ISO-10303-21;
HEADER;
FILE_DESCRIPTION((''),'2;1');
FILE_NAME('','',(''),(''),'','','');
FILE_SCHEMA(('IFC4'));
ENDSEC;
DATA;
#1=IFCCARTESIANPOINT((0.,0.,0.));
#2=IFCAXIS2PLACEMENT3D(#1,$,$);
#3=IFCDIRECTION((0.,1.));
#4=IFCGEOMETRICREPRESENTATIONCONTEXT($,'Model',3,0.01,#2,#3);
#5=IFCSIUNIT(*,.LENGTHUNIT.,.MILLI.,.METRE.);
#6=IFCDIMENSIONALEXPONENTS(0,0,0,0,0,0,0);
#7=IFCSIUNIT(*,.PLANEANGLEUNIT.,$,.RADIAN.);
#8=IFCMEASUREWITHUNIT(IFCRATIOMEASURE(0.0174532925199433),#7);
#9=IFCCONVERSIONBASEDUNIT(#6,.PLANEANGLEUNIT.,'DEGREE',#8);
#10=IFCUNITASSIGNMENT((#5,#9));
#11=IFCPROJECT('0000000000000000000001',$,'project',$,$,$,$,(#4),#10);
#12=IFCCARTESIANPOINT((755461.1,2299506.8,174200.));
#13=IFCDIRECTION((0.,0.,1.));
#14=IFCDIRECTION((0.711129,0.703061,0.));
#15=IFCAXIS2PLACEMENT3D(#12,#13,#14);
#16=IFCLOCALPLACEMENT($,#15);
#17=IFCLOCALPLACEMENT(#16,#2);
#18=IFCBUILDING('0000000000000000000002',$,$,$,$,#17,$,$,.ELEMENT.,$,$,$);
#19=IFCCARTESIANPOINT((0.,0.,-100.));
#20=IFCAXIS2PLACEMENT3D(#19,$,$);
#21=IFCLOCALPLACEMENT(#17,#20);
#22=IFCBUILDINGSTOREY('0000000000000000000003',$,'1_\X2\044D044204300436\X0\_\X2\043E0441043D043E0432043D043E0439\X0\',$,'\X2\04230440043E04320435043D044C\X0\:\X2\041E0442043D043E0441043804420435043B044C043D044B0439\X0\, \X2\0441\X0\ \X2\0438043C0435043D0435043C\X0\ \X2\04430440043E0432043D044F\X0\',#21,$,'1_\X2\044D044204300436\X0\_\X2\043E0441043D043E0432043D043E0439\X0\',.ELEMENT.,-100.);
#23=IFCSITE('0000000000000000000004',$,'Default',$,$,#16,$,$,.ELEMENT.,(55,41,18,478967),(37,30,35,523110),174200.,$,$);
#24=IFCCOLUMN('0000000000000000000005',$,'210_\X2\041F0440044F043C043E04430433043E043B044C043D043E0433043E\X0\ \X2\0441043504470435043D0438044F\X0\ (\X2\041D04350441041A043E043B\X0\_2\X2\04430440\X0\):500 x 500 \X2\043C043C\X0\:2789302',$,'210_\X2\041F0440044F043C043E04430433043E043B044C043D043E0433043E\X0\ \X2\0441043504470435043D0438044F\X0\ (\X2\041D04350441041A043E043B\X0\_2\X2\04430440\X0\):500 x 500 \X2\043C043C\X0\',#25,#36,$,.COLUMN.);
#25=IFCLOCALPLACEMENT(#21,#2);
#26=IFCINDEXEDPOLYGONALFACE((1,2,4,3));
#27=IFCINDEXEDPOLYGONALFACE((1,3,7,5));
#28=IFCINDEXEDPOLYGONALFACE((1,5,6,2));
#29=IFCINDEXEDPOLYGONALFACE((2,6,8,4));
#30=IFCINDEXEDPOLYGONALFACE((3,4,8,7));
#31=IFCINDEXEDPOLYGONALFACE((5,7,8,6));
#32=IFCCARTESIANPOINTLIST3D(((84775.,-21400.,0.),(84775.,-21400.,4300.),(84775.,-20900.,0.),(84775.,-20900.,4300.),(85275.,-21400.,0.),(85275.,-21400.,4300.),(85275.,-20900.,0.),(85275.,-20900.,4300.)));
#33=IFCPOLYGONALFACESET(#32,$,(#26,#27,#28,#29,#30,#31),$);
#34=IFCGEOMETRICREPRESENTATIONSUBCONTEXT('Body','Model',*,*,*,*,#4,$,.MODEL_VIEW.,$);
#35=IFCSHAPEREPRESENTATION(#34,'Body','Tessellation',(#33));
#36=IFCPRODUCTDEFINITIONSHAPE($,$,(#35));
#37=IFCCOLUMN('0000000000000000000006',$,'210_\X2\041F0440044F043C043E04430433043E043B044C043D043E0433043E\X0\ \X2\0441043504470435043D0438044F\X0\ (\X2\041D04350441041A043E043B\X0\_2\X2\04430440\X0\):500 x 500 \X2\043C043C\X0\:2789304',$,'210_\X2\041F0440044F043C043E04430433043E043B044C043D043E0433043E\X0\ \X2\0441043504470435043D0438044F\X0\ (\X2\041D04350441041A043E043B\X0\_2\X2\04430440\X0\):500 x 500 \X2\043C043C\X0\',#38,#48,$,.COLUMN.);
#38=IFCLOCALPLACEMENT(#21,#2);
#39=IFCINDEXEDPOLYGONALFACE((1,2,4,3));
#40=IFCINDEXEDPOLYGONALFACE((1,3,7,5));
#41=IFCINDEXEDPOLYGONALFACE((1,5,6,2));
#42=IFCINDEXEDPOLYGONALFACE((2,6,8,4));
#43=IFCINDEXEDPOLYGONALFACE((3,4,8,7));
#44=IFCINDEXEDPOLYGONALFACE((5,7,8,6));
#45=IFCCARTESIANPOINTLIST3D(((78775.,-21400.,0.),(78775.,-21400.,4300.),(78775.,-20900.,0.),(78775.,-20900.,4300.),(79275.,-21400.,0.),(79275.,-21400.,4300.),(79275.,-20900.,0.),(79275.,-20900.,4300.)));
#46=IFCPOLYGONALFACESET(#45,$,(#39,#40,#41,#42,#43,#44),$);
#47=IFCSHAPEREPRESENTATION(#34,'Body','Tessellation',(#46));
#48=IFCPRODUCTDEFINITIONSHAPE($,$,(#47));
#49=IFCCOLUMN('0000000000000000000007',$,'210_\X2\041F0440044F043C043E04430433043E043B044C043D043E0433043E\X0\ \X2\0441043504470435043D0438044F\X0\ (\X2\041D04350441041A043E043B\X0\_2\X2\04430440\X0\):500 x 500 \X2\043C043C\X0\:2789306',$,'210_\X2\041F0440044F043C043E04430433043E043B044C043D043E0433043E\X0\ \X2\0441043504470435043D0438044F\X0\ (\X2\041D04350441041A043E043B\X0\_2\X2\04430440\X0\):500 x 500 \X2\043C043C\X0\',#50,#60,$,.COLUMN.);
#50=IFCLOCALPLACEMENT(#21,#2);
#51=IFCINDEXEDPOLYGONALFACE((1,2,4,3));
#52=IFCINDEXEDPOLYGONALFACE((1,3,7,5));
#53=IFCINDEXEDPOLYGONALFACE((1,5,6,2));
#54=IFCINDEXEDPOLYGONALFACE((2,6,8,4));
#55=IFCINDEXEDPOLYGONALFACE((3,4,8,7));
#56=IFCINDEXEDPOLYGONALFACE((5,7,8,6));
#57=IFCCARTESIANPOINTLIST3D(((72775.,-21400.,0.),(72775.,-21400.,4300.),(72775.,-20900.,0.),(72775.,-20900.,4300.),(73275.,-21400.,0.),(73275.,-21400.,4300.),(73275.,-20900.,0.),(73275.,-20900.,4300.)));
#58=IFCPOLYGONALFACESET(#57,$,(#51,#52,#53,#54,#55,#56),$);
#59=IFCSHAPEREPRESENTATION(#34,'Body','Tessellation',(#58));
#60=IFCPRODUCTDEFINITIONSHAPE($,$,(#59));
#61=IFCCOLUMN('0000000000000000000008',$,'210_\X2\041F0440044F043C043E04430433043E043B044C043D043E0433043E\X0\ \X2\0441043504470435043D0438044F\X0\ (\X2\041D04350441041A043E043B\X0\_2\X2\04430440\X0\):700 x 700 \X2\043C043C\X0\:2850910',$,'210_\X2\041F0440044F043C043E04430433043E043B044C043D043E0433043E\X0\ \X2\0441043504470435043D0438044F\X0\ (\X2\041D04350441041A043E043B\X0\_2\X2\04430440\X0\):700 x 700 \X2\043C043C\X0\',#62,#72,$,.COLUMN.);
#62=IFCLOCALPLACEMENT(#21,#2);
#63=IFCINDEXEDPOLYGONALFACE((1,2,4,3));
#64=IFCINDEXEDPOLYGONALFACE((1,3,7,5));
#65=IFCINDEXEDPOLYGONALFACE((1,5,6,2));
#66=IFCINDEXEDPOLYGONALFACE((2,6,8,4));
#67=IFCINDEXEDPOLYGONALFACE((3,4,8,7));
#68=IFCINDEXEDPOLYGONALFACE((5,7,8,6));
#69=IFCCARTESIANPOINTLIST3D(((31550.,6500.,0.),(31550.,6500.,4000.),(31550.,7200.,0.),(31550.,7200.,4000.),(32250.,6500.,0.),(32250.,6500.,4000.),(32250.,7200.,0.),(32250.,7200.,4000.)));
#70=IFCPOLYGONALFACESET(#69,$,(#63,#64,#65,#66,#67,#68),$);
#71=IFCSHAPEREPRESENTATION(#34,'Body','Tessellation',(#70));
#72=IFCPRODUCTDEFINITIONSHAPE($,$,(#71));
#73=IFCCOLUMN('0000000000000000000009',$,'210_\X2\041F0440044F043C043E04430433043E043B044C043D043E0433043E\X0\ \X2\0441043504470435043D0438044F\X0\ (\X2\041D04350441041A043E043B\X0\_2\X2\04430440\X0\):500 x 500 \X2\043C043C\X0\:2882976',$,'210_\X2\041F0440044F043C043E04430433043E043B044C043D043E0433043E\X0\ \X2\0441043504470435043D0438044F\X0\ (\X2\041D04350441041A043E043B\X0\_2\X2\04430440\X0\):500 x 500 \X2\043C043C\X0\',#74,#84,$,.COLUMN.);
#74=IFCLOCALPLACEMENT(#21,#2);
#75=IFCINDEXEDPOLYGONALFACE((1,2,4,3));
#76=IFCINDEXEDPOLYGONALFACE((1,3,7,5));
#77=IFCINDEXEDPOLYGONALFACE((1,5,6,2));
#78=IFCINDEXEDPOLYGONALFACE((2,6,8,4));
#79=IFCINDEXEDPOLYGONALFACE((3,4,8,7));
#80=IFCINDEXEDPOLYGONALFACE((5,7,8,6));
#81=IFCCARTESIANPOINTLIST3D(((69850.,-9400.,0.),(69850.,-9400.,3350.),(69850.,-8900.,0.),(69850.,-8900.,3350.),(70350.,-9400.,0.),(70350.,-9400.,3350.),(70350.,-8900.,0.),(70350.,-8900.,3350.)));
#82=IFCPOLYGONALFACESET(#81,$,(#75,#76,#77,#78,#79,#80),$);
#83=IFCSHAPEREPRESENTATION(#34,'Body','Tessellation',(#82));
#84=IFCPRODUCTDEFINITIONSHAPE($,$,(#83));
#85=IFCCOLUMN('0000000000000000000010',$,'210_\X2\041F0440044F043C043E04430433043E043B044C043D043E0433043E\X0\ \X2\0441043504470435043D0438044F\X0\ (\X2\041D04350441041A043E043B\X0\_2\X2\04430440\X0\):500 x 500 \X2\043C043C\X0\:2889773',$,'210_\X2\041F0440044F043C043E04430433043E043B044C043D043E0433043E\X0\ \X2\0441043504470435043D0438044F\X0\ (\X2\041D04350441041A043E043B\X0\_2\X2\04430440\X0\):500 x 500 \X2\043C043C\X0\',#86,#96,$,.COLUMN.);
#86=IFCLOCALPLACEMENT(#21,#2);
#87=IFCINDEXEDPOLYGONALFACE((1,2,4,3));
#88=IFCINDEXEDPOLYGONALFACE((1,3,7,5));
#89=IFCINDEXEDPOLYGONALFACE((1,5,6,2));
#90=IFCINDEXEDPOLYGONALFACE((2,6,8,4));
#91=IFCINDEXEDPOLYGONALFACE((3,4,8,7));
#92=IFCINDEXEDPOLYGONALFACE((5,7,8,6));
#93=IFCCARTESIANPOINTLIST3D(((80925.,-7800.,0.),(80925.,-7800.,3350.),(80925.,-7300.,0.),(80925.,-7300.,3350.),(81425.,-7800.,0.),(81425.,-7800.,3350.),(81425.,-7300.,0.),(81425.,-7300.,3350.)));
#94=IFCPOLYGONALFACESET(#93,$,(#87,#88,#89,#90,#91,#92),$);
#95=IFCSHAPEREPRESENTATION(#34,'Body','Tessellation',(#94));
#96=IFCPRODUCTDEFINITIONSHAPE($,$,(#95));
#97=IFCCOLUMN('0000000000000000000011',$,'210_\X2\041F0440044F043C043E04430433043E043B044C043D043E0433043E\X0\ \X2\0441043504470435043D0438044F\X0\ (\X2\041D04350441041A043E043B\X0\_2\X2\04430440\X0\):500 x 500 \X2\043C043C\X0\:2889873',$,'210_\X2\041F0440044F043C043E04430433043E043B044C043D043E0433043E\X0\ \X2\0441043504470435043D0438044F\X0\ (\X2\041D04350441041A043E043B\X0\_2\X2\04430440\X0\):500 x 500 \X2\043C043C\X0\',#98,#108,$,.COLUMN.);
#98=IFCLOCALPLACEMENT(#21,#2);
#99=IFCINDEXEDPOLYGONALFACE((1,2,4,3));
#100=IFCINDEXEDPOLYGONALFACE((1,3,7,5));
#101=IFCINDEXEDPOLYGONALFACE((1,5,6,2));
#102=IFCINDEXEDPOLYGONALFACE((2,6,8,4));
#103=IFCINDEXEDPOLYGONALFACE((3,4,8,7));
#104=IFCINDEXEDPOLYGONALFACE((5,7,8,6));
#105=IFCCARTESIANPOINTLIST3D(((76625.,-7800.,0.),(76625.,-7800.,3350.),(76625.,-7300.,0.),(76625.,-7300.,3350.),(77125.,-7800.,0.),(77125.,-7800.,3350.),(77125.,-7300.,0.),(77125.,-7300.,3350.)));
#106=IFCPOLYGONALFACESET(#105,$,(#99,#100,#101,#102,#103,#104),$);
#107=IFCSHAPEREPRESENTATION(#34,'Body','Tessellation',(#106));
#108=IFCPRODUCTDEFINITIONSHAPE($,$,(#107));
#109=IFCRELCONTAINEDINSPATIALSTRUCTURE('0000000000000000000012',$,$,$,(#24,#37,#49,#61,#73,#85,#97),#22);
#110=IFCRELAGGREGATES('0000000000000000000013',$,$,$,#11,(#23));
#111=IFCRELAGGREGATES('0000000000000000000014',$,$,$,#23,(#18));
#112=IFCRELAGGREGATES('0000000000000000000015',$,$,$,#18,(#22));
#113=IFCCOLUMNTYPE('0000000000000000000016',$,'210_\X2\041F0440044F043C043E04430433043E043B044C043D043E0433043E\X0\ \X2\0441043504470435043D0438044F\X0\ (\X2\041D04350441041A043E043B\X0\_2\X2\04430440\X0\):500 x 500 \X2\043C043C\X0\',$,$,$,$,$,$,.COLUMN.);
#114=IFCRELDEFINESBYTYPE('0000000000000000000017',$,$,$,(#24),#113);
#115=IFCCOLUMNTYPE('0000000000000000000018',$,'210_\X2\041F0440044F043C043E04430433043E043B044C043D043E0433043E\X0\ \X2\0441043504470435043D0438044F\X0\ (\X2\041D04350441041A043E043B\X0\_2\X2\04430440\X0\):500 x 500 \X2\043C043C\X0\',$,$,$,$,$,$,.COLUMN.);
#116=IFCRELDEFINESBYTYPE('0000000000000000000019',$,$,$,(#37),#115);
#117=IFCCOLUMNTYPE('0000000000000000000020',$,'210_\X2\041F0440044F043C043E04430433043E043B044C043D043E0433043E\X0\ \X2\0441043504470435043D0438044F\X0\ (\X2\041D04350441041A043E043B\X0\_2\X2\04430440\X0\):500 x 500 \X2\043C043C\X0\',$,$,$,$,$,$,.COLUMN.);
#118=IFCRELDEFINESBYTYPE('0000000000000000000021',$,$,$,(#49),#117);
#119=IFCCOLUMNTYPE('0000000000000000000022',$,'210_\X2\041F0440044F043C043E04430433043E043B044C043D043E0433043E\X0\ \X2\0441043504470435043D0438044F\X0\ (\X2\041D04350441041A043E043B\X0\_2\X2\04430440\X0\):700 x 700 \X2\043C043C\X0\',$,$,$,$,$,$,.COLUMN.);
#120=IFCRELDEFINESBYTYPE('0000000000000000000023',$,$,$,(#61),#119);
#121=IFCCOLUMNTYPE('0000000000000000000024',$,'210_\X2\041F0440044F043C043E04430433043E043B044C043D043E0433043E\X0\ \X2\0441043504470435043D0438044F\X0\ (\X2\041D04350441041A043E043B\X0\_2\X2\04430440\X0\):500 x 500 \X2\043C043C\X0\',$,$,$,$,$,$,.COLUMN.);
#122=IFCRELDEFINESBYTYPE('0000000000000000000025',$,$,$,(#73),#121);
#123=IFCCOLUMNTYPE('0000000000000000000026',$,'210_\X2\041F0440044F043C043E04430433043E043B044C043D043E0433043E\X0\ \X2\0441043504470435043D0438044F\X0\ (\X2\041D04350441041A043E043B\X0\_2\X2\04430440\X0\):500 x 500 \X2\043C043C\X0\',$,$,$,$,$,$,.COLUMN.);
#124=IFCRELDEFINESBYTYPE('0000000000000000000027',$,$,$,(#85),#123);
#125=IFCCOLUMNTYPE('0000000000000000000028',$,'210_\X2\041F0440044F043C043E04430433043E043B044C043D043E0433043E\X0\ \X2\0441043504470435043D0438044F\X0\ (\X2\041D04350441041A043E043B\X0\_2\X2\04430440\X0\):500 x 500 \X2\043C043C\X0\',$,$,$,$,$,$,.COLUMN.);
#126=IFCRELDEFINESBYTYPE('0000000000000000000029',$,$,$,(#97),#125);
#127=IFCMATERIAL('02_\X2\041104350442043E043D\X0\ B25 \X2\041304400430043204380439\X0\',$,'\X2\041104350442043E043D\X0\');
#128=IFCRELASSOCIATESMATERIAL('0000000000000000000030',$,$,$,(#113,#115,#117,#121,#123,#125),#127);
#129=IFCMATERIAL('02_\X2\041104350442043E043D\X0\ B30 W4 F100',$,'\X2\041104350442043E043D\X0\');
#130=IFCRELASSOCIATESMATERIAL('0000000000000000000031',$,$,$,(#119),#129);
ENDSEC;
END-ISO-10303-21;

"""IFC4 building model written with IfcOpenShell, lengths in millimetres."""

from ifc_helpers import new_model, entity, si_unit, converted_unit, direction, frame, origin, place, context, subcontext, project, spatial, indexed_curve, outline, extrude, source, transform, mapped, material, type_object, type_shapes, element, save


model = new_model("IFC4")

# Units and contexts
model_context = context("Model", 3, precision=0.01, world=origin(), true_north=direction((0.0, 1.0)))
body_context = subcontext(model_context, "Body", "Model", "MODEL_VIEW")
ifc_project = project(units=[si_unit("LENGTHUNIT", "METRE", prefix="MILLI"), converted_unit("PLANEANGLEUNIT", "DEGREE", entity("IfcRatioMeasure", 0.0174532925199433), si_unit("PLANEANGLEUNIT", "RADIAN"), dimensions=[0, 0, 0, 0, 0, 0, 0])], contexts=[model_context])

# Site, building, storey
site_placement = place(None, frame((755461.1, 2299506.8, 174200.0), z_axis=(0.0, 0.0, 1.0), x_axis=(0.711129, 0.703061, 0.0)))
site = spatial("IfcSite", under=ifc_project, at=site_placement, Name="Default", CompositionType="ELEMENT", RefLatitude=(55, 41, 18, 478967), RefLongitude=(37, 30, 35, 523110), RefElevation=174200.0)
building_placement = place(site_placement, origin())
building = spatial("IfcBuilding", under=site, at=building_placement, CompositionType="ELEMENT")
storey_placement = place(building_placement, frame((0.0, 0.0, -100.0)))
storey = spatial("IfcBuildingStorey", under=building, at=storey_placement, Name="1_этаж_основной", ObjectType="Уровень:Относительный, с именем уровня", LongName="1_этаж_основной", CompositionType="ELEMENT", Elevation=-100.0)

# Columns
ifc_material_1 = material(Name="02_Бетон B25 Гравий", Category="Бетон")
ifc_material_2 = material(Name="02_Бетон B30 W4 F100", Category="Бетон")
column_type_1 = type_object("IfcColumnType", Name="210_Прямоугольного сечения (НесКол_2ур):500 x 500 мм", PredefinedType="COLUMN", material=ifc_material_1)
shared_shape_1 = source(origin(), body_context, "Body", "SweptSolid", [
    extrude(outline(indexed_curve([(-250.0, -250.0), (250.0, -250.0), (250.0, 250.0), (-250.0, 250.0), (-250.0, -250.0)], self_intersect=False)), frame((85025.0, -21150.0, -100.0), z_axis=(0.0, 0.0, 1.0), x_axis=(0.0, -1.0, 0.0)), (0.0, 0.0, 1.0), 4300.0),
])
type_shapes(column_type_1, [shared_shape_1])
column_1_placement = place(storey_placement, frame((0.0, 0.0, 100.0)))
element("IfcColumn", 1, at=column_1_placement, inside=storey, type_object=column_type_1, Name="210_Прямоугольного сечения (НесКол_2ур):500 x 500 мм:2789302", ObjectType="210_Прямоугольного сечения (НесКол_2ур):500 x 500 мм", PredefinedType="COLUMN", context=body_context, shape_type="MappedRepresentation", body=[
    mapped(shared_shape_1, transform((0.0, 0.0, 0.0), scale=1.0)),
])
column_type_2 = type_object("IfcColumnType", Name="210_Прямоугольного сечения (НесКол_2ур):500 x 500 мм", PredefinedType="COLUMN", material=ifc_material_1)
shared_shape_2 = source(origin(), body_context, "Body", "SweptSolid", [
    extrude(outline(indexed_curve([(-250.0, -250.0), (250.0, -250.0), (250.0, 250.0), (-250.0, 250.0), (-250.0, -250.0)], self_intersect=False)), frame((79025.0, -21150.0, -100.0), z_axis=(0.0, 0.0, 1.0), x_axis=(0.0, -1.0, 0.0)), (0.0, 0.0, 1.0), 4300.0),
])
type_shapes(column_type_2, [shared_shape_2])
column_2_placement = place(storey_placement, frame((0.0, 0.0, 100.0)))
element("IfcColumn", 2, at=column_2_placement, inside=storey, type_object=column_type_2, Name="210_Прямоугольного сечения (НесКол_2ур):500 x 500 мм:2789304", ObjectType="210_Прямоугольного сечения (НесКол_2ур):500 x 500 мм", PredefinedType="COLUMN", context=body_context, shape_type="MappedRepresentation", body=[
    mapped(shared_shape_2, transform((0.0, 0.0, 0.0), scale=1.0)),
])
column_type_3 = type_object("IfcColumnType", Name="210_Прямоугольного сечения (НесКол_2ур):500 x 500 мм", PredefinedType="COLUMN", material=ifc_material_1)
shared_shape_3 = source(origin(), body_context, "Body", "SweptSolid", [
    extrude(outline(indexed_curve([(-250.0, -250.0), (250.0, -250.0), (250.0, 250.0), (-250.0, 250.0), (-250.0, -250.0)], self_intersect=False)), frame((73025.0, -21150.0, -100.0), z_axis=(0.0, 0.0, 1.0), x_axis=(0.0, -1.0, 0.0)), (0.0, 0.0, 1.0), 4300.0),
])
type_shapes(column_type_3, [shared_shape_3])
column_3_placement = place(storey_placement, frame((0.0, 0.0, 100.0)))
element("IfcColumn", 3, at=column_3_placement, inside=storey, type_object=column_type_3, Name="210_Прямоугольного сечения (НесКол_2ур):500 x 500 мм:2789306", ObjectType="210_Прямоугольного сечения (НесКол_2ур):500 x 500 мм", PredefinedType="COLUMN", context=body_context, shape_type="MappedRepresentation", body=[
    mapped(shared_shape_3, transform((0.0, 0.0, 0.0), scale=1.0)),
])
column_type_4 = type_object("IfcColumnType", Name="210_Прямоугольного сечения (НесКол_2ур):700 x 700 мм", PredefinedType="COLUMN", material=ifc_material_2)
shared_shape_4 = source(origin(), body_context, "Body", "SweptSolid", [
    extrude(outline(indexed_curve([(-350.0, -350.0), (350.0, -350.0), (350.0, 350.0), (-350.0, 350.0), (-350.0, -350.0)], self_intersect=False)), frame((31900.0, 6850.0, -100.0), z_axis=(0.0, 0.0, 1.0), x_axis=(0.0, -1.0, 0.0)), (0.0, 0.0, 1.0), 4000.0),
])
type_shapes(column_type_4, [shared_shape_4])
column_4_placement = place(storey_placement, frame((0.0, 0.0, 100.0)))
element("IfcColumn", 4, at=column_4_placement, inside=storey, type_object=column_type_4, Name="210_Прямоугольного сечения (НесКол_2ур):700 x 700 мм:2850910", ObjectType="210_Прямоугольного сечения (НесКол_2ур):700 x 700 мм", PredefinedType="COLUMN", context=body_context, shape_type="MappedRepresentation", body=[
    mapped(shared_shape_4, transform((0.0, 0.0, 0.0), scale=1.0)),
])
column_type_5 = type_object("IfcColumnType", Name="210_Прямоугольного сечения (НесКол_2ур):500 x 500 мм", PredefinedType="COLUMN", material=ifc_material_1)
shared_shape_5 = source(origin(), body_context, "Body", "SweptSolid", [
    extrude(outline(indexed_curve([(-250.0, -250.0), (250.0, -250.0), (250.0, 250.0), (-250.0, 250.0), (-250.0, -250.0)], self_intersect=False)), frame((70100.0, -9150.0, -100.0), z_axis=(0.0, 0.0, 1.0), x_axis=(0.0, -1.0, 0.0)), (0.0, 0.0, 1.0), 3350.0),
])
type_shapes(column_type_5, [shared_shape_5])
column_5_placement = place(storey_placement, frame((0.0, 0.0, 100.0)))
element("IfcColumn", 5, at=column_5_placement, inside=storey, type_object=column_type_5, Name="210_Прямоугольного сечения (НесКол_2ур):500 x 500 мм:2882976", ObjectType="210_Прямоугольного сечения (НесКол_2ур):500 x 500 мм", PredefinedType="COLUMN", context=body_context, shape_type="MappedRepresentation", body=[
    mapped(shared_shape_5, transform((0.0, 0.0, 0.0), scale=1.0)),
])
column_type_6 = type_object("IfcColumnType", Name="210_Прямоугольного сечения (НесКол_2ур):500 x 500 мм", PredefinedType="COLUMN", material=ifc_material_1)
shared_shape_6 = source(origin(), body_context, "Body", "SweptSolid", [
    extrude(outline(indexed_curve([(-250.0, -250.0), (250.0, -250.0), (250.0, 250.0), (-250.0, 250.0), (-250.0, -250.0)], self_intersect=False)), frame((81175.0, -7550.0, -100.0), z_axis=(0.0, 0.0, 1.0), x_axis=(0.0, -1.0, 0.0)), (0.0, 0.0, 1.0), 3350.0),
])
type_shapes(column_type_6, [shared_shape_6])
column_6_placement = place(storey_placement, frame((0.0, 0.0, 100.0)))
element("IfcColumn", 6, at=column_6_placement, inside=storey, type_object=column_type_6, Name="210_Прямоугольного сечения (НесКол_2ур):500 x 500 мм:2889773", ObjectType="210_Прямоугольного сечения (НесКол_2ур):500 x 500 мм", PredefinedType="COLUMN", context=body_context, shape_type="MappedRepresentation", body=[
    mapped(shared_shape_6, transform((0.0, 0.0, 0.0), scale=1.0)),
])
column_type_7 = type_object("IfcColumnType", Name="210_Прямоугольного сечения (НесКол_2ур):500 x 500 мм", PredefinedType="COLUMN", material=ifc_material_1)
shared_shape_7 = source(origin(), body_context, "Body", "SweptSolid", [
    extrude(outline(indexed_curve([(-250.0, -250.0), (250.0, -250.0), (250.0, 250.0), (-250.0, 250.0), (-250.0, -250.0)], self_intersect=False)), frame((76875.0, -7550.0, -100.0), z_axis=(0.0, 0.0, 1.0), x_axis=(0.0, -1.0, 0.0)), (0.0, 0.0, 1.0), 3350.0),
])
type_shapes(column_type_7, [shared_shape_7])
column_7_placement = place(storey_placement, frame((0.0, 0.0, 100.0)))
element("IfcColumn", 7, at=column_7_placement, inside=storey, type_object=column_type_7, Name="210_Прямоугольного сечения (НесКол_2ур):500 x 500 мм:2889873", ObjectType="210_Прямоугольного сечения (НесКол_2ур):500 x 500 мм", PredefinedType="COLUMN", context=body_context, shape_type="MappedRepresentation", body=[
    mapped(shared_shape_7, transform((0.0, 0.0, 0.0), scale=1.0)),
])

save(model, "model.ifc")
